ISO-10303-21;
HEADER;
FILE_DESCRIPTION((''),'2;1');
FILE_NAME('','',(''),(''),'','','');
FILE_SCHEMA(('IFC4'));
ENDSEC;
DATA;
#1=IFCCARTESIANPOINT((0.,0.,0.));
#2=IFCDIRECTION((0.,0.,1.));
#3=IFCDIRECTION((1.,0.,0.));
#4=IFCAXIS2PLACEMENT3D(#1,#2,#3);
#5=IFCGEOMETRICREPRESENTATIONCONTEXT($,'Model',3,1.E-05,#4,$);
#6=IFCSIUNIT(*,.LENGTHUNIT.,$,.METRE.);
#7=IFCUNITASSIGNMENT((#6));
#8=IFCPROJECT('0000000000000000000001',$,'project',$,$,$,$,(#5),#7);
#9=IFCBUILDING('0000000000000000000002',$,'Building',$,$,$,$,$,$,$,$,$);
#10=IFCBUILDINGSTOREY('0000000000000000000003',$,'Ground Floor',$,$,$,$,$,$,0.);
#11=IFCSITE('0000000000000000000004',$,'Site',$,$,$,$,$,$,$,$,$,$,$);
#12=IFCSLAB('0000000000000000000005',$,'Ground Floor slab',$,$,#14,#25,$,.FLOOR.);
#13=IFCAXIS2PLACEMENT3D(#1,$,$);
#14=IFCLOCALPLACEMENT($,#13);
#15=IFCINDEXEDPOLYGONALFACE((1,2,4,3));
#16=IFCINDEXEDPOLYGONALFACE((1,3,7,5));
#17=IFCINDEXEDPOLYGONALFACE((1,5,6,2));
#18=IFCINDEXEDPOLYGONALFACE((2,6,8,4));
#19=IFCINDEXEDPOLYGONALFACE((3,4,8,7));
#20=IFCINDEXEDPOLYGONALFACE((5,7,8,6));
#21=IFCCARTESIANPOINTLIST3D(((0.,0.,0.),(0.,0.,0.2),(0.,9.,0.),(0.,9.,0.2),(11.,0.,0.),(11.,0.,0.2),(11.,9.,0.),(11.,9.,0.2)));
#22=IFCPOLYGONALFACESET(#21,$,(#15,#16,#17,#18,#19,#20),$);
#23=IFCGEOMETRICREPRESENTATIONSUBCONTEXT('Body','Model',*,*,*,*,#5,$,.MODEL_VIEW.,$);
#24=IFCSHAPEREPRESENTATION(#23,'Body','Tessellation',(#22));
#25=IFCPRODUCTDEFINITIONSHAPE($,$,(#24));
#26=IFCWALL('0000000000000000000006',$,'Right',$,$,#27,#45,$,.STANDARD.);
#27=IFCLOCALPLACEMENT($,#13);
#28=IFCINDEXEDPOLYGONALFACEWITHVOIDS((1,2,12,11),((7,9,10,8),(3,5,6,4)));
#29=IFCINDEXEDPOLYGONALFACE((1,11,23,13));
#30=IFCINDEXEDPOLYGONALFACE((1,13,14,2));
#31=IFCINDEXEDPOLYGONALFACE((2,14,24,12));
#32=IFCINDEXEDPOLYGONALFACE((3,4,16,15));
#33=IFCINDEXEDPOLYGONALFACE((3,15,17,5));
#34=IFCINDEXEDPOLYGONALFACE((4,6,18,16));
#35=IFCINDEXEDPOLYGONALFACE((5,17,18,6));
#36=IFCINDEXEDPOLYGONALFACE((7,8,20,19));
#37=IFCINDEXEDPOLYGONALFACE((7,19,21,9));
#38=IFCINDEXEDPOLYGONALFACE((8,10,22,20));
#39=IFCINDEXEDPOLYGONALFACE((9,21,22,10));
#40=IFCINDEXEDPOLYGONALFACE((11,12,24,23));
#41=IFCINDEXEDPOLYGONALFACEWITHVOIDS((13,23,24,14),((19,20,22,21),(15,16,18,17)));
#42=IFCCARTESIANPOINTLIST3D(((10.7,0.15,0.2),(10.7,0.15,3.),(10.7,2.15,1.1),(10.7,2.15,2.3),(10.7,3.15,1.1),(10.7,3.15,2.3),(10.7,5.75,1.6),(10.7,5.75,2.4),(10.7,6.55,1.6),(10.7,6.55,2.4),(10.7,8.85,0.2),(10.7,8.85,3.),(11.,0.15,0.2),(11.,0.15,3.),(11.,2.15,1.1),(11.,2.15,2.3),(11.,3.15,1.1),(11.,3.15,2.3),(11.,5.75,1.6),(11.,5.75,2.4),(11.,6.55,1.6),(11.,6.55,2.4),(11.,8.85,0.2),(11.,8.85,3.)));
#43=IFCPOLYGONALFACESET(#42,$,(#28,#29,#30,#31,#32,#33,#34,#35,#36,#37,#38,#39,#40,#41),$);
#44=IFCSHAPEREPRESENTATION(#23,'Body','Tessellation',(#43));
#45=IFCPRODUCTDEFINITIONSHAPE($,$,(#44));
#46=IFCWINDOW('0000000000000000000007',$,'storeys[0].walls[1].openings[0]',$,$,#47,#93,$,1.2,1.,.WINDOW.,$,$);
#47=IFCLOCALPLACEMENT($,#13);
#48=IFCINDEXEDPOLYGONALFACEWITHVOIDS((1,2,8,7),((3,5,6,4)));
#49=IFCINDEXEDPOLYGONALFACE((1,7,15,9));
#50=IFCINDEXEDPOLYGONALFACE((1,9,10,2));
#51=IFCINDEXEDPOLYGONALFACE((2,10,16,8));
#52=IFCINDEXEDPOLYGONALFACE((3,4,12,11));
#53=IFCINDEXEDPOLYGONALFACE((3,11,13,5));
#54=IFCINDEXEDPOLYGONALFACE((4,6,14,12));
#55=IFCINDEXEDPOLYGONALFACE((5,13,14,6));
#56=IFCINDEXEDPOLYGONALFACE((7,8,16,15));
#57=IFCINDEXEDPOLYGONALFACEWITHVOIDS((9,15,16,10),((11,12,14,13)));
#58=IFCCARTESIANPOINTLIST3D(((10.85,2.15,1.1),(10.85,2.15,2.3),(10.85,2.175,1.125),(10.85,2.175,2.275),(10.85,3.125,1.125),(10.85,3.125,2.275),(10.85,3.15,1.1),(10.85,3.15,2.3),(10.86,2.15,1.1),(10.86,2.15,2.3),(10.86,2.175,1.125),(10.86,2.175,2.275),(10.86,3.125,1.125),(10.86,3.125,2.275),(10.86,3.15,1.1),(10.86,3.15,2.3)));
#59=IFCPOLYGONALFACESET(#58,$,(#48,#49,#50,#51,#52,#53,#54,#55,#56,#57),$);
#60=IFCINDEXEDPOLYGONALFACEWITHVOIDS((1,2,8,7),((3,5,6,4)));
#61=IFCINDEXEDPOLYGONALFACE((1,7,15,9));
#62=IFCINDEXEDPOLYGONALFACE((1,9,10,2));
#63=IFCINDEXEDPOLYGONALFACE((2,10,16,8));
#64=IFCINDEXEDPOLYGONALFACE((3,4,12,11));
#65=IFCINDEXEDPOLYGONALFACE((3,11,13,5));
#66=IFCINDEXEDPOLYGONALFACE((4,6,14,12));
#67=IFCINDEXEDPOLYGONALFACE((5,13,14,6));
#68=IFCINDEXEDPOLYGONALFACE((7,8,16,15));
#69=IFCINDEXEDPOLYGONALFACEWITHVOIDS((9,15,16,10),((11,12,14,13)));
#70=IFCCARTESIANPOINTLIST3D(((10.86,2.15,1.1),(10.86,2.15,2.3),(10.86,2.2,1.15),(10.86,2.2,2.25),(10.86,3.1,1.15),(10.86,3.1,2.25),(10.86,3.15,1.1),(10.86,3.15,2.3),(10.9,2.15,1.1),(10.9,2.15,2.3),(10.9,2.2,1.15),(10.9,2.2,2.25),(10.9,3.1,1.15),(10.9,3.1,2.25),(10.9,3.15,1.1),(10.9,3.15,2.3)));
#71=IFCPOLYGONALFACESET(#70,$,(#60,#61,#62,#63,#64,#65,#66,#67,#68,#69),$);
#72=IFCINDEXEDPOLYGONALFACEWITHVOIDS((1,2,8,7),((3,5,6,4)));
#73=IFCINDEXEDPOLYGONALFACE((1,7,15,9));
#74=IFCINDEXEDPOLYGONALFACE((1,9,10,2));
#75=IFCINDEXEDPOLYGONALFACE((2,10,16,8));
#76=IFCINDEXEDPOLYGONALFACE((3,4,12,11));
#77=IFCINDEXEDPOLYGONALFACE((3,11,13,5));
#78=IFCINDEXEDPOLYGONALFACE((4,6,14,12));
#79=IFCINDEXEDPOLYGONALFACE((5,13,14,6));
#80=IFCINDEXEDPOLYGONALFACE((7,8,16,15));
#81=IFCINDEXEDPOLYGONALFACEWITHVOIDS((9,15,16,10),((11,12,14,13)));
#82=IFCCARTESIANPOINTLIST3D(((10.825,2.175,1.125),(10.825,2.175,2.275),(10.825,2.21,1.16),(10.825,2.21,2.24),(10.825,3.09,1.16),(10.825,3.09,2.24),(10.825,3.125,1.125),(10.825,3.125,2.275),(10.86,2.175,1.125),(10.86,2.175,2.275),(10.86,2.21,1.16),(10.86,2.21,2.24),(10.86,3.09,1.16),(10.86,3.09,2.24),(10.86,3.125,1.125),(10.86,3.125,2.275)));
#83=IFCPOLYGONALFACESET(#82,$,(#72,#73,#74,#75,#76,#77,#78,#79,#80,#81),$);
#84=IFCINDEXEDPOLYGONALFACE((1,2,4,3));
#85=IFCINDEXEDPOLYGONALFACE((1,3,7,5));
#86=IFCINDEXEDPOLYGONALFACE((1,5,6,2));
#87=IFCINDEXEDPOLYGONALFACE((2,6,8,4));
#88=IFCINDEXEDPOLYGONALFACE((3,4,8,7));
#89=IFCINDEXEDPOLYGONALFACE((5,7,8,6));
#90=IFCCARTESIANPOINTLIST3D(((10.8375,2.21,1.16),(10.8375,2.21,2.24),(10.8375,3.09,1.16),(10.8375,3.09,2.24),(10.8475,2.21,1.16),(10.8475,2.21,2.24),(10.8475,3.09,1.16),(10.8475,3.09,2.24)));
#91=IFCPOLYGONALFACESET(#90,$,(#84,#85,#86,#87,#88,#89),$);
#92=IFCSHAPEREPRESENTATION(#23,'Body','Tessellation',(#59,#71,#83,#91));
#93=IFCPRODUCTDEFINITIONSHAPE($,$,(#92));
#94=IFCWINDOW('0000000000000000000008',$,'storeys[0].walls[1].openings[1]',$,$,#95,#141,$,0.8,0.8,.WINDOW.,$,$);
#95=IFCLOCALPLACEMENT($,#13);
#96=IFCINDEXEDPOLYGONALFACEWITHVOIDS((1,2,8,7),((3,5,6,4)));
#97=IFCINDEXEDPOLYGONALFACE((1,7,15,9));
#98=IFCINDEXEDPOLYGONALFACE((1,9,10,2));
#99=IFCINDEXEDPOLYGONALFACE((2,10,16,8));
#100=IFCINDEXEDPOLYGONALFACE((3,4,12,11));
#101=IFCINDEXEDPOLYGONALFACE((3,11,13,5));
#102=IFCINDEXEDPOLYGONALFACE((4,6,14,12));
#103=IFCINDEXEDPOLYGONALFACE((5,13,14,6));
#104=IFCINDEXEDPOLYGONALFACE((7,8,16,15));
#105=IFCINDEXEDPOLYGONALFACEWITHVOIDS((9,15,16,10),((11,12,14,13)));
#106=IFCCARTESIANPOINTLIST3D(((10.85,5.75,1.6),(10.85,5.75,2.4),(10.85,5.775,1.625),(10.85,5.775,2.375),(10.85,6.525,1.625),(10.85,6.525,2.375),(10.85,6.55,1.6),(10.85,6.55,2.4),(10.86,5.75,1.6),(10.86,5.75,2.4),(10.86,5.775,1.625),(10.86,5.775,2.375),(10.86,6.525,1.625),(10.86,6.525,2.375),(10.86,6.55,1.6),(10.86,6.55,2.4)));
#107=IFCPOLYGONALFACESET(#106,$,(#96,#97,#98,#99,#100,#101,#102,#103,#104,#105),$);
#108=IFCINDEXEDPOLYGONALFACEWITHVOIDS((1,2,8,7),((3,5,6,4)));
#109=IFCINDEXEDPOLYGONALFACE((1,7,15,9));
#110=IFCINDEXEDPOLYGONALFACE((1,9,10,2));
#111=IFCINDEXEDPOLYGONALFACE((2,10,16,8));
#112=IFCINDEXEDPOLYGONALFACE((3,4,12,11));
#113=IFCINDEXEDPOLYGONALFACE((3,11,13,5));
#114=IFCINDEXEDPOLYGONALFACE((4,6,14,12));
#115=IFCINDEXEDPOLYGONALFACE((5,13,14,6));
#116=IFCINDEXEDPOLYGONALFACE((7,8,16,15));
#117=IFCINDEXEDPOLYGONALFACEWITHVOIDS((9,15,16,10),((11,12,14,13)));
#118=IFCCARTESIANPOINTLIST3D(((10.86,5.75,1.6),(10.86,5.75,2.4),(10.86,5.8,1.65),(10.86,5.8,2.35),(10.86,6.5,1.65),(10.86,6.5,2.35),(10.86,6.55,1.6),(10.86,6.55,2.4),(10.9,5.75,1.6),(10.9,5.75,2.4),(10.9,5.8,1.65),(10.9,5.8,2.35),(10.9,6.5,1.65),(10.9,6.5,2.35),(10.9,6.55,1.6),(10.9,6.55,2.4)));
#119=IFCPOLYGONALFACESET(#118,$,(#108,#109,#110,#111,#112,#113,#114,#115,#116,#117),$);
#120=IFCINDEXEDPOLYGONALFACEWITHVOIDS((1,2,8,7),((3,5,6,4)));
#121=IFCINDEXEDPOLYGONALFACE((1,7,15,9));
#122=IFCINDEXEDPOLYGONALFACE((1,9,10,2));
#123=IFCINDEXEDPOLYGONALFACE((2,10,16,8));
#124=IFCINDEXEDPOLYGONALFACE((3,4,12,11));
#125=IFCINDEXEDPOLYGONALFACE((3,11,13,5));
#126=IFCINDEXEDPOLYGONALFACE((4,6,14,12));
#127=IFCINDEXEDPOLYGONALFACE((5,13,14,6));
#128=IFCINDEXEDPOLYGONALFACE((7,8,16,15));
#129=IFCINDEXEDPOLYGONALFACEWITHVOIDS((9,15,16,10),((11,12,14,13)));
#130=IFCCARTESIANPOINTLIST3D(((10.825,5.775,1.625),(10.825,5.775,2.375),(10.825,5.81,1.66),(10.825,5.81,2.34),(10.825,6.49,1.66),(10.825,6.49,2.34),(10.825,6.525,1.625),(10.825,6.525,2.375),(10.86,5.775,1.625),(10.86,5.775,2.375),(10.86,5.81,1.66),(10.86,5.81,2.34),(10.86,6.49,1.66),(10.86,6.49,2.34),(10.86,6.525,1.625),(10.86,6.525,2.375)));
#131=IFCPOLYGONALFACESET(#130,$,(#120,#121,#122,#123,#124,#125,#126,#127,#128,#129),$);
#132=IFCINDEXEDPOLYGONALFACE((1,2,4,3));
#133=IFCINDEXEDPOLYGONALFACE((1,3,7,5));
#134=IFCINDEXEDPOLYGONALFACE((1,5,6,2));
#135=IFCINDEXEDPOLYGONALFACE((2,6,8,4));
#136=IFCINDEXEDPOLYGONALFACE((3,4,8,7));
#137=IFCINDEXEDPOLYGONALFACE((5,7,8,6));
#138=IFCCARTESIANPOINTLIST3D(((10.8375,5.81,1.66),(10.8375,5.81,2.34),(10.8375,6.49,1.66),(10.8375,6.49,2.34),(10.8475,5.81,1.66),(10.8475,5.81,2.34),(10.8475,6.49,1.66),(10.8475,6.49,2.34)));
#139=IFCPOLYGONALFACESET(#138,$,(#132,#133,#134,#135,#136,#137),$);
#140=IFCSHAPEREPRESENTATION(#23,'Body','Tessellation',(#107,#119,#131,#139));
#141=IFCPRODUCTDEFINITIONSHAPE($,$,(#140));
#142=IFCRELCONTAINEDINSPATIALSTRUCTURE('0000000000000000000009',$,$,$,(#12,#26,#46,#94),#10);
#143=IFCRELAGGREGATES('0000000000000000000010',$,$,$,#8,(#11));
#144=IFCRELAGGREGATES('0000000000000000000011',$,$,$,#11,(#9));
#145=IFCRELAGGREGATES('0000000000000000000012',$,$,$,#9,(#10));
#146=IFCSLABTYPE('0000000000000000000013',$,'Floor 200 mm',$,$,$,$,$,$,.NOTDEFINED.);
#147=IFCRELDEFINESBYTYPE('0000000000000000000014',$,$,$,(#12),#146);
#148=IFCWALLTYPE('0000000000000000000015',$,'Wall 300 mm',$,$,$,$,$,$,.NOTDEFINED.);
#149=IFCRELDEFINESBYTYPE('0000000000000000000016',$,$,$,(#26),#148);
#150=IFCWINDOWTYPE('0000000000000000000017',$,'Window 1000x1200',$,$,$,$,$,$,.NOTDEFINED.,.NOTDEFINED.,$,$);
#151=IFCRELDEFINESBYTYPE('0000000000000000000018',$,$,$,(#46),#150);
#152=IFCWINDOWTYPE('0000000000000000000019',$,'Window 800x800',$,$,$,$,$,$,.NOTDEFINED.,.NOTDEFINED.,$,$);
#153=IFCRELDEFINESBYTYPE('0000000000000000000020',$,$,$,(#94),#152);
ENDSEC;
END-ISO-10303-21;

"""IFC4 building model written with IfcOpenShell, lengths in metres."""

from ifc_helpers import new_model, si_unit, frame, origin_with_axes, place, context, subcontext, project, spatial, line, indexed_curve, outline, extrude, type_object, element, fill, save


model = new_model("IFC4")

# Units and contexts
model_context = context("Model", 3, precision=1e-05, world=origin_with_axes())
body_context = subcontext(model_context, "Body", "Model", "MODEL_VIEW")
ifc_project = project(units=[si_unit("LENGTHUNIT", "METRE")], contexts=[model_context])

# Site, building, storey
site = spatial("IfcSite", under=ifc_project, Name="Site")
building = spatial("IfcBuilding", under=site, Name="Building")
storey = spatial("IfcBuildingStorey", under=building, Name="Ground Floor", Elevation=0.0)

# Slab
slab_type = type_object("IfcSlabType", Name="Floor 200 mm", PredefinedType="NOTDEFINED")
slab_placement = place(None, origin_with_axes())
element("IfcSlab", 1, at=slab_placement, inside=storey, type_object=slab_type, Name="Ground Floor slab", PredefinedType="FLOOR", context=body_context, shape_type="SweptSolid", body=[
    extrude(outline(indexed_curve([(0.0, 0.0), (11.0, 0.0), (11.0, 9.0), (0.0, 9.0)])), None, (0.0, 0.0, 1.0), 0.2),
])

# Shared definitions
wall_type_1 = type_object("IfcWallType", Name="Wall 300 mm", PredefinedType="NOTDEFINED")

# Wall, openings, windows
wall_1_placement = place(None, frame((10.85, 0.15, 0.2), z_axis=(0.0, 0.0, 1.0), x_axis=(0.0, 1.0, 0.0)))
wall_1 = element("IfcWall", 2, at=wall_1_placement, inside=storey, type_object=wall_type_1, Name="Right", PredefinedType="STANDARD", context=body_context, shape_type="SweptSolid", body=[
    extrude(outline(indexed_curve([(0.0, 0.0), (0.0, 0.3), (8.7, 0.3), (8.7, 0.0), (0.0, 0.0)], self_intersect=False)), frame((0.0, -0.15, 0.0), z_axis=(0.0, 0.0, 1.0), x_axis=(1.0, 0.0, 0.0)), (0.0, 0.0, 1.0), 2.8),
])
opening_1_placement = place(wall_1_placement, frame((2.0, -0.16, 0.9), z_axis=(0.0, 0.0, 1.0), x_axis=(1.0, 0.0, 0.0)))
opening_1 = element("IfcOpeningElement", 3, at=opening_1_placement, cuts=wall_1, context=body_context, shape_type="SweptSolid", body=[
    extrude(outline(indexed_curve([(0.0, 0.0), (0.0, 0.32), (1.0, 0.32), (1.0, 0.0), (0.0, 0.0)], self_intersect=False)), origin_with_axes(), (0.0, 0.0, 1.0), 1.2),
])
opening_2_placement = place(wall_1_placement, frame((5.6, -0.16, 1.4), z_axis=(0.0, 0.0, 1.0), x_axis=(1.0, 0.0, 0.0)))
opening_2 = element("IfcOpeningElement", 4, at=opening_2_placement, cuts=wall_1, context=body_context, shape_type="SweptSolid", body=[
    extrude(outline(indexed_curve([(0.0, 0.0), (0.0, 0.32), (0.8, 0.32), (0.8, 0.0), (0.0, 0.0)], self_intersect=False)), origin_with_axes(), (0.0, 0.0, 1.0), 0.8),
])
window_type_1 = type_object("IfcWindowType", Name="Window 1000x1200", PartitioningType="NOTDEFINED", PredefinedType="NOTDEFINED")
window_1_placement = place(None, frame((10.95, 2.15, 1.1), z_axis=(0.0, 0.0, 1.0), x_axis=(0.0, 1.0, 0.0)))
window_1 = element("IfcWindow", 5, at=window_1_placement, inside=storey, type_object=window_type_1, Name="storeys[0].walls[1].openings[0]", OverallHeight=1.2, OverallWidth=1.0, PredefinedType="WINDOW", context=body_context, shape_type="SweptSolid", body=[
    extrude(outline(indexed_curve([(0.0, 0.0), (1.0, 0.0), (1.0, 1.2), (0.0, 1.2)], segments=[line(1, 2, 3, 4, 1)]), holes=[indexed_curve([(0.025, 0.025), (0.975, 0.025), (0.975, 1.175), (0.025, 1.175)], segments=[line(1, 2, 3, 4, 1)])]), frame((0.0, 0.09, 0.0), z_axis=(0.0, -1.0, 0.0), x_axis=(1.0, 0.0, 0.0)), (0.0, 0.0, -1.0), 0.01),
    extrude(outline(indexed_curve([(0.0, 0.0), (1.0, 0.0), (1.0, 1.2), (0.0, 1.2)], segments=[line(1, 2, 3, 4, 1)]), holes=[indexed_curve([(0.05, 0.05), (0.95, 0.05), (0.95, 1.15), (0.05, 1.15)], segments=[line(1, 2, 3, 4, 1)])]), frame((0.0, 0.05, 0.0), z_axis=(0.0, -1.0, 0.0), x_axis=(1.0, 0.0, 0.0)), (0.0, 0.0, -1.0), 0.04),
    extrude(outline(indexed_curve([(0.0, 0.0), (0.95, 0.0), (0.95, 1.15), (0.0, 1.15)], segments=[line(1, 2, 3, 4, 1)]), holes=[indexed_curve([(0.035, 0.035), (0.915, 0.035), (0.915, 1.115), (0.035, 1.115)], segments=[line(1, 2, 3, 4, 1)])]), frame((0.025, 0.09, 0.025), z_axis=(0.0, -1.0, 0.0), x_axis=(1.0, 0.0, 0.0)), (0.0, 0.0, -1.0), 0.035),
    extrude(outline(indexed_curve([(0.035, 0.035), (0.915, 0.035), (0.915, 1.115), (0.035, 1.115)], segments=[line(1, 2, 3, 4, 1)])), frame((0.025, 0.1025, 0.025), z_axis=(0.0, -1.0, 0.0), x_axis=(1.0, 0.0, 0.0)), (0.0, 0.0, -1.0), 0.01),
])
fill(opening_1, window_1)
window_type_2 = type_object("IfcWindowType", Name="Window 800x800", PartitioningType="NOTDEFINED", PredefinedType="NOTDEFINED")
window_2_placement = place(None, frame((10.95, 5.75, 1.6), z_axis=(0.0, 0.0, 1.0), x_axis=(0.0, 1.0, 0.0)))
window_2 = element("IfcWindow", 6, at=window_2_placement, inside=storey, type_object=window_type_2, Name="storeys[0].walls[1].openings[1]", OverallHeight=0.8, OverallWidth=0.8, PredefinedType="WINDOW", context=body_context, shape_type="SweptSolid", body=[
    extrude(outline(indexed_curve([(0.0, 0.0), (0.8, 0.0), (0.8, 0.8), (0.0, 0.8)], segments=[line(1, 2, 3, 4, 1)]), holes=[indexed_curve([(0.025, 0.025), (0.775, 0.025), (0.775, 0.775), (0.025, 0.775)], segments=[line(1, 2, 3, 4, 1)])]), frame((0.0, 0.09, 0.0), z_axis=(0.0, -1.0, 0.0), x_axis=(1.0, 0.0, 0.0)), (0.0, 0.0, -1.0), 0.01),
    extrude(outline(indexed_curve([(0.0, 0.0), (0.8, 0.0), (0.8, 0.8), (0.0, 0.8)], segments=[line(1, 2, 3, 4, 1)]), holes=[indexed_curve([(0.05, 0.05), (0.75, 0.05), (0.75, 0.75), (0.05, 0.75)], segments=[line(1, 2, 3, 4, 1)])]), frame((0.0, 0.05, 0.0), z_axis=(0.0, -1.0, 0.0), x_axis=(1.0, 0.0, 0.0)), (0.0, 0.0, -1.0), 0.04),
    extrude(outline(indexed_curve([(0.0, 0.0), (0.75, 0.0), (0.75, 0.75), (0.0, 0.75)], segments=[line(1, 2, 3, 4, 1)]), holes=[indexed_curve([(0.035, 0.035), (0.715, 0.035), (0.715, 0.715), (0.035, 0.715)], segments=[line(1, 2, 3, 4, 1)])]), frame((0.025, 0.09, 0.025), z_axis=(0.0, -1.0, 0.0), x_axis=(1.0, 0.0, 0.0)), (0.0, 0.0, -1.0), 0.035),
    extrude(outline(indexed_curve([(0.035, 0.035), (0.715, 0.035), (0.715, 0.715), (0.035, 0.715)], segments=[line(1, 2, 3, 4, 1)])), frame((0.025, 0.1025, 0.025), z_axis=(0.0, -1.0, 0.0), x_axis=(1.0, 0.0, 0.0)), (0.0, 0.0, -1.0), 0.01),
])
fill(opening_2, window_2)

save(model, "model.ifc")
